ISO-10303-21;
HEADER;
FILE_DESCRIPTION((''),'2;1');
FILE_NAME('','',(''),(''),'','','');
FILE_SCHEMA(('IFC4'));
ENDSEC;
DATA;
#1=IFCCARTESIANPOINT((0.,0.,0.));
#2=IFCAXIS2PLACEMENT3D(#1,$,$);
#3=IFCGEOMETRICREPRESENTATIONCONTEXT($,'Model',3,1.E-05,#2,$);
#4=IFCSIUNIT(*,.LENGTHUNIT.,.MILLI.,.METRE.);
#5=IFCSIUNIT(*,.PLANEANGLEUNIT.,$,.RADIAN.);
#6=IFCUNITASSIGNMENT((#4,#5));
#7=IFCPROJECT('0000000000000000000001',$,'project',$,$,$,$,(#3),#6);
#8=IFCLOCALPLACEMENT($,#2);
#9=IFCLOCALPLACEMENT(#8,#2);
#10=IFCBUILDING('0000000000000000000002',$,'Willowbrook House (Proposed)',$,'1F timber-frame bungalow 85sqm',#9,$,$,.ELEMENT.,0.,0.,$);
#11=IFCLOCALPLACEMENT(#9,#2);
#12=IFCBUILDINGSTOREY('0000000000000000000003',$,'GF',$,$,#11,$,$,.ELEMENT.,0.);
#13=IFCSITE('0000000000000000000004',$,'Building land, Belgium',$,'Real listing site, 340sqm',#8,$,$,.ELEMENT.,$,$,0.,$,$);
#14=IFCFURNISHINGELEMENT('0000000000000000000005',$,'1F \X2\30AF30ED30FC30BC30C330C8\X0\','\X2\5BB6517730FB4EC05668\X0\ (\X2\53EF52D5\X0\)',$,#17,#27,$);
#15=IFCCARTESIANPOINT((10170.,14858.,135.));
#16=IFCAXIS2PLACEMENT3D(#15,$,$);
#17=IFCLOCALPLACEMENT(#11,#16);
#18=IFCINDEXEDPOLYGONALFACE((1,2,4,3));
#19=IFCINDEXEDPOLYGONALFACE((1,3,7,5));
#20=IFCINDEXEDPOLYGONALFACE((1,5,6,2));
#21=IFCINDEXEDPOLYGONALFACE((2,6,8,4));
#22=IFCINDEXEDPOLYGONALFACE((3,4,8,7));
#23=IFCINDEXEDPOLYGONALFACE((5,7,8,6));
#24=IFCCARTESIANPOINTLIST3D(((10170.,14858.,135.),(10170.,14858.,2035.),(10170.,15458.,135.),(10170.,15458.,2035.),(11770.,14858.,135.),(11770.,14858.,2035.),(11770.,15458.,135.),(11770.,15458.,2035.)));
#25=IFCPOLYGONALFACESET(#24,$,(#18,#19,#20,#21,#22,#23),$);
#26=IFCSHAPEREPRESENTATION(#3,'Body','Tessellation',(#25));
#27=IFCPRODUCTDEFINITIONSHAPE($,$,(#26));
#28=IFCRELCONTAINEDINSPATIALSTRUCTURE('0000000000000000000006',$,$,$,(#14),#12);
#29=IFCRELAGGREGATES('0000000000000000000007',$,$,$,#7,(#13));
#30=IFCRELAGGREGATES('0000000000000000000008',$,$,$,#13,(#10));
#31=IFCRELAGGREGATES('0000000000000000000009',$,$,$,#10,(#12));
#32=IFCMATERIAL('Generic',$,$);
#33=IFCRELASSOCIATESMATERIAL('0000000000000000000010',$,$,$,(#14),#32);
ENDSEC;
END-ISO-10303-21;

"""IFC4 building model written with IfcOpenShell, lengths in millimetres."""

from ifc_helpers import new_model, si_unit, frame, frame_2d, origin, place, context, project, spatial, rectangle, extrude, material, element, save


model = new_model("IFC4")

# Units and contexts
model_context = context("Model", 3, precision=1e-05, world=origin())
ifc_project = project(units=[si_unit("LENGTHUNIT", "METRE", prefix="MILLI"), si_unit("PLANEANGLEUNIT", "RADIAN")], contexts=[model_context])

# Site, building, storey
site_placement = place(None, origin())
site = spatial("IfcSite", under=ifc_project, at=site_placement, Name="Building land, Belgium", ObjectType="Real listing site, 340sqm", CompositionType="ELEMENT", RefElevation=0.0)
building_placement = place(site_placement, origin())
building = spatial("IfcBuilding", under=site, at=building_placement, Name="Willowbrook House (Proposed)", ObjectType="1F timber-frame bungalow 85sqm", CompositionType="ELEMENT", ElevationOfRefHeight=0.0, ElevationOfTerrain=0.0)
storey_placement = place(building_placement, origin())
storey = spatial("IfcBuildingStorey", under=building, at=storey_placement, Name="GF", CompositionType="ELEMENT", Elevation=0.0)

# Shared definitions
ifc_material_1 = material(Name="Generic")

# Furnishing element
furnishing_placement = place(storey_placement, frame((10170.0, 14858.0, 135.0)))
element("IfcFurnishingElement", 1, at=furnishing_placement, inside=storey, material=ifc_material_1, Name="1F クローゼット", Description="家具・什器 (可動)", context=model_context, shape_type="SweptSolid", body=[
    extrude(rectangle(XDim=1600.0, YDim=600.0, at=frame_2d((800.0, 300.0))), frame((10170.0, 14858.0, 135.0)), (0.0, 0.0, 1.0), 1900.0),
])

save(model, "model.ifc")
